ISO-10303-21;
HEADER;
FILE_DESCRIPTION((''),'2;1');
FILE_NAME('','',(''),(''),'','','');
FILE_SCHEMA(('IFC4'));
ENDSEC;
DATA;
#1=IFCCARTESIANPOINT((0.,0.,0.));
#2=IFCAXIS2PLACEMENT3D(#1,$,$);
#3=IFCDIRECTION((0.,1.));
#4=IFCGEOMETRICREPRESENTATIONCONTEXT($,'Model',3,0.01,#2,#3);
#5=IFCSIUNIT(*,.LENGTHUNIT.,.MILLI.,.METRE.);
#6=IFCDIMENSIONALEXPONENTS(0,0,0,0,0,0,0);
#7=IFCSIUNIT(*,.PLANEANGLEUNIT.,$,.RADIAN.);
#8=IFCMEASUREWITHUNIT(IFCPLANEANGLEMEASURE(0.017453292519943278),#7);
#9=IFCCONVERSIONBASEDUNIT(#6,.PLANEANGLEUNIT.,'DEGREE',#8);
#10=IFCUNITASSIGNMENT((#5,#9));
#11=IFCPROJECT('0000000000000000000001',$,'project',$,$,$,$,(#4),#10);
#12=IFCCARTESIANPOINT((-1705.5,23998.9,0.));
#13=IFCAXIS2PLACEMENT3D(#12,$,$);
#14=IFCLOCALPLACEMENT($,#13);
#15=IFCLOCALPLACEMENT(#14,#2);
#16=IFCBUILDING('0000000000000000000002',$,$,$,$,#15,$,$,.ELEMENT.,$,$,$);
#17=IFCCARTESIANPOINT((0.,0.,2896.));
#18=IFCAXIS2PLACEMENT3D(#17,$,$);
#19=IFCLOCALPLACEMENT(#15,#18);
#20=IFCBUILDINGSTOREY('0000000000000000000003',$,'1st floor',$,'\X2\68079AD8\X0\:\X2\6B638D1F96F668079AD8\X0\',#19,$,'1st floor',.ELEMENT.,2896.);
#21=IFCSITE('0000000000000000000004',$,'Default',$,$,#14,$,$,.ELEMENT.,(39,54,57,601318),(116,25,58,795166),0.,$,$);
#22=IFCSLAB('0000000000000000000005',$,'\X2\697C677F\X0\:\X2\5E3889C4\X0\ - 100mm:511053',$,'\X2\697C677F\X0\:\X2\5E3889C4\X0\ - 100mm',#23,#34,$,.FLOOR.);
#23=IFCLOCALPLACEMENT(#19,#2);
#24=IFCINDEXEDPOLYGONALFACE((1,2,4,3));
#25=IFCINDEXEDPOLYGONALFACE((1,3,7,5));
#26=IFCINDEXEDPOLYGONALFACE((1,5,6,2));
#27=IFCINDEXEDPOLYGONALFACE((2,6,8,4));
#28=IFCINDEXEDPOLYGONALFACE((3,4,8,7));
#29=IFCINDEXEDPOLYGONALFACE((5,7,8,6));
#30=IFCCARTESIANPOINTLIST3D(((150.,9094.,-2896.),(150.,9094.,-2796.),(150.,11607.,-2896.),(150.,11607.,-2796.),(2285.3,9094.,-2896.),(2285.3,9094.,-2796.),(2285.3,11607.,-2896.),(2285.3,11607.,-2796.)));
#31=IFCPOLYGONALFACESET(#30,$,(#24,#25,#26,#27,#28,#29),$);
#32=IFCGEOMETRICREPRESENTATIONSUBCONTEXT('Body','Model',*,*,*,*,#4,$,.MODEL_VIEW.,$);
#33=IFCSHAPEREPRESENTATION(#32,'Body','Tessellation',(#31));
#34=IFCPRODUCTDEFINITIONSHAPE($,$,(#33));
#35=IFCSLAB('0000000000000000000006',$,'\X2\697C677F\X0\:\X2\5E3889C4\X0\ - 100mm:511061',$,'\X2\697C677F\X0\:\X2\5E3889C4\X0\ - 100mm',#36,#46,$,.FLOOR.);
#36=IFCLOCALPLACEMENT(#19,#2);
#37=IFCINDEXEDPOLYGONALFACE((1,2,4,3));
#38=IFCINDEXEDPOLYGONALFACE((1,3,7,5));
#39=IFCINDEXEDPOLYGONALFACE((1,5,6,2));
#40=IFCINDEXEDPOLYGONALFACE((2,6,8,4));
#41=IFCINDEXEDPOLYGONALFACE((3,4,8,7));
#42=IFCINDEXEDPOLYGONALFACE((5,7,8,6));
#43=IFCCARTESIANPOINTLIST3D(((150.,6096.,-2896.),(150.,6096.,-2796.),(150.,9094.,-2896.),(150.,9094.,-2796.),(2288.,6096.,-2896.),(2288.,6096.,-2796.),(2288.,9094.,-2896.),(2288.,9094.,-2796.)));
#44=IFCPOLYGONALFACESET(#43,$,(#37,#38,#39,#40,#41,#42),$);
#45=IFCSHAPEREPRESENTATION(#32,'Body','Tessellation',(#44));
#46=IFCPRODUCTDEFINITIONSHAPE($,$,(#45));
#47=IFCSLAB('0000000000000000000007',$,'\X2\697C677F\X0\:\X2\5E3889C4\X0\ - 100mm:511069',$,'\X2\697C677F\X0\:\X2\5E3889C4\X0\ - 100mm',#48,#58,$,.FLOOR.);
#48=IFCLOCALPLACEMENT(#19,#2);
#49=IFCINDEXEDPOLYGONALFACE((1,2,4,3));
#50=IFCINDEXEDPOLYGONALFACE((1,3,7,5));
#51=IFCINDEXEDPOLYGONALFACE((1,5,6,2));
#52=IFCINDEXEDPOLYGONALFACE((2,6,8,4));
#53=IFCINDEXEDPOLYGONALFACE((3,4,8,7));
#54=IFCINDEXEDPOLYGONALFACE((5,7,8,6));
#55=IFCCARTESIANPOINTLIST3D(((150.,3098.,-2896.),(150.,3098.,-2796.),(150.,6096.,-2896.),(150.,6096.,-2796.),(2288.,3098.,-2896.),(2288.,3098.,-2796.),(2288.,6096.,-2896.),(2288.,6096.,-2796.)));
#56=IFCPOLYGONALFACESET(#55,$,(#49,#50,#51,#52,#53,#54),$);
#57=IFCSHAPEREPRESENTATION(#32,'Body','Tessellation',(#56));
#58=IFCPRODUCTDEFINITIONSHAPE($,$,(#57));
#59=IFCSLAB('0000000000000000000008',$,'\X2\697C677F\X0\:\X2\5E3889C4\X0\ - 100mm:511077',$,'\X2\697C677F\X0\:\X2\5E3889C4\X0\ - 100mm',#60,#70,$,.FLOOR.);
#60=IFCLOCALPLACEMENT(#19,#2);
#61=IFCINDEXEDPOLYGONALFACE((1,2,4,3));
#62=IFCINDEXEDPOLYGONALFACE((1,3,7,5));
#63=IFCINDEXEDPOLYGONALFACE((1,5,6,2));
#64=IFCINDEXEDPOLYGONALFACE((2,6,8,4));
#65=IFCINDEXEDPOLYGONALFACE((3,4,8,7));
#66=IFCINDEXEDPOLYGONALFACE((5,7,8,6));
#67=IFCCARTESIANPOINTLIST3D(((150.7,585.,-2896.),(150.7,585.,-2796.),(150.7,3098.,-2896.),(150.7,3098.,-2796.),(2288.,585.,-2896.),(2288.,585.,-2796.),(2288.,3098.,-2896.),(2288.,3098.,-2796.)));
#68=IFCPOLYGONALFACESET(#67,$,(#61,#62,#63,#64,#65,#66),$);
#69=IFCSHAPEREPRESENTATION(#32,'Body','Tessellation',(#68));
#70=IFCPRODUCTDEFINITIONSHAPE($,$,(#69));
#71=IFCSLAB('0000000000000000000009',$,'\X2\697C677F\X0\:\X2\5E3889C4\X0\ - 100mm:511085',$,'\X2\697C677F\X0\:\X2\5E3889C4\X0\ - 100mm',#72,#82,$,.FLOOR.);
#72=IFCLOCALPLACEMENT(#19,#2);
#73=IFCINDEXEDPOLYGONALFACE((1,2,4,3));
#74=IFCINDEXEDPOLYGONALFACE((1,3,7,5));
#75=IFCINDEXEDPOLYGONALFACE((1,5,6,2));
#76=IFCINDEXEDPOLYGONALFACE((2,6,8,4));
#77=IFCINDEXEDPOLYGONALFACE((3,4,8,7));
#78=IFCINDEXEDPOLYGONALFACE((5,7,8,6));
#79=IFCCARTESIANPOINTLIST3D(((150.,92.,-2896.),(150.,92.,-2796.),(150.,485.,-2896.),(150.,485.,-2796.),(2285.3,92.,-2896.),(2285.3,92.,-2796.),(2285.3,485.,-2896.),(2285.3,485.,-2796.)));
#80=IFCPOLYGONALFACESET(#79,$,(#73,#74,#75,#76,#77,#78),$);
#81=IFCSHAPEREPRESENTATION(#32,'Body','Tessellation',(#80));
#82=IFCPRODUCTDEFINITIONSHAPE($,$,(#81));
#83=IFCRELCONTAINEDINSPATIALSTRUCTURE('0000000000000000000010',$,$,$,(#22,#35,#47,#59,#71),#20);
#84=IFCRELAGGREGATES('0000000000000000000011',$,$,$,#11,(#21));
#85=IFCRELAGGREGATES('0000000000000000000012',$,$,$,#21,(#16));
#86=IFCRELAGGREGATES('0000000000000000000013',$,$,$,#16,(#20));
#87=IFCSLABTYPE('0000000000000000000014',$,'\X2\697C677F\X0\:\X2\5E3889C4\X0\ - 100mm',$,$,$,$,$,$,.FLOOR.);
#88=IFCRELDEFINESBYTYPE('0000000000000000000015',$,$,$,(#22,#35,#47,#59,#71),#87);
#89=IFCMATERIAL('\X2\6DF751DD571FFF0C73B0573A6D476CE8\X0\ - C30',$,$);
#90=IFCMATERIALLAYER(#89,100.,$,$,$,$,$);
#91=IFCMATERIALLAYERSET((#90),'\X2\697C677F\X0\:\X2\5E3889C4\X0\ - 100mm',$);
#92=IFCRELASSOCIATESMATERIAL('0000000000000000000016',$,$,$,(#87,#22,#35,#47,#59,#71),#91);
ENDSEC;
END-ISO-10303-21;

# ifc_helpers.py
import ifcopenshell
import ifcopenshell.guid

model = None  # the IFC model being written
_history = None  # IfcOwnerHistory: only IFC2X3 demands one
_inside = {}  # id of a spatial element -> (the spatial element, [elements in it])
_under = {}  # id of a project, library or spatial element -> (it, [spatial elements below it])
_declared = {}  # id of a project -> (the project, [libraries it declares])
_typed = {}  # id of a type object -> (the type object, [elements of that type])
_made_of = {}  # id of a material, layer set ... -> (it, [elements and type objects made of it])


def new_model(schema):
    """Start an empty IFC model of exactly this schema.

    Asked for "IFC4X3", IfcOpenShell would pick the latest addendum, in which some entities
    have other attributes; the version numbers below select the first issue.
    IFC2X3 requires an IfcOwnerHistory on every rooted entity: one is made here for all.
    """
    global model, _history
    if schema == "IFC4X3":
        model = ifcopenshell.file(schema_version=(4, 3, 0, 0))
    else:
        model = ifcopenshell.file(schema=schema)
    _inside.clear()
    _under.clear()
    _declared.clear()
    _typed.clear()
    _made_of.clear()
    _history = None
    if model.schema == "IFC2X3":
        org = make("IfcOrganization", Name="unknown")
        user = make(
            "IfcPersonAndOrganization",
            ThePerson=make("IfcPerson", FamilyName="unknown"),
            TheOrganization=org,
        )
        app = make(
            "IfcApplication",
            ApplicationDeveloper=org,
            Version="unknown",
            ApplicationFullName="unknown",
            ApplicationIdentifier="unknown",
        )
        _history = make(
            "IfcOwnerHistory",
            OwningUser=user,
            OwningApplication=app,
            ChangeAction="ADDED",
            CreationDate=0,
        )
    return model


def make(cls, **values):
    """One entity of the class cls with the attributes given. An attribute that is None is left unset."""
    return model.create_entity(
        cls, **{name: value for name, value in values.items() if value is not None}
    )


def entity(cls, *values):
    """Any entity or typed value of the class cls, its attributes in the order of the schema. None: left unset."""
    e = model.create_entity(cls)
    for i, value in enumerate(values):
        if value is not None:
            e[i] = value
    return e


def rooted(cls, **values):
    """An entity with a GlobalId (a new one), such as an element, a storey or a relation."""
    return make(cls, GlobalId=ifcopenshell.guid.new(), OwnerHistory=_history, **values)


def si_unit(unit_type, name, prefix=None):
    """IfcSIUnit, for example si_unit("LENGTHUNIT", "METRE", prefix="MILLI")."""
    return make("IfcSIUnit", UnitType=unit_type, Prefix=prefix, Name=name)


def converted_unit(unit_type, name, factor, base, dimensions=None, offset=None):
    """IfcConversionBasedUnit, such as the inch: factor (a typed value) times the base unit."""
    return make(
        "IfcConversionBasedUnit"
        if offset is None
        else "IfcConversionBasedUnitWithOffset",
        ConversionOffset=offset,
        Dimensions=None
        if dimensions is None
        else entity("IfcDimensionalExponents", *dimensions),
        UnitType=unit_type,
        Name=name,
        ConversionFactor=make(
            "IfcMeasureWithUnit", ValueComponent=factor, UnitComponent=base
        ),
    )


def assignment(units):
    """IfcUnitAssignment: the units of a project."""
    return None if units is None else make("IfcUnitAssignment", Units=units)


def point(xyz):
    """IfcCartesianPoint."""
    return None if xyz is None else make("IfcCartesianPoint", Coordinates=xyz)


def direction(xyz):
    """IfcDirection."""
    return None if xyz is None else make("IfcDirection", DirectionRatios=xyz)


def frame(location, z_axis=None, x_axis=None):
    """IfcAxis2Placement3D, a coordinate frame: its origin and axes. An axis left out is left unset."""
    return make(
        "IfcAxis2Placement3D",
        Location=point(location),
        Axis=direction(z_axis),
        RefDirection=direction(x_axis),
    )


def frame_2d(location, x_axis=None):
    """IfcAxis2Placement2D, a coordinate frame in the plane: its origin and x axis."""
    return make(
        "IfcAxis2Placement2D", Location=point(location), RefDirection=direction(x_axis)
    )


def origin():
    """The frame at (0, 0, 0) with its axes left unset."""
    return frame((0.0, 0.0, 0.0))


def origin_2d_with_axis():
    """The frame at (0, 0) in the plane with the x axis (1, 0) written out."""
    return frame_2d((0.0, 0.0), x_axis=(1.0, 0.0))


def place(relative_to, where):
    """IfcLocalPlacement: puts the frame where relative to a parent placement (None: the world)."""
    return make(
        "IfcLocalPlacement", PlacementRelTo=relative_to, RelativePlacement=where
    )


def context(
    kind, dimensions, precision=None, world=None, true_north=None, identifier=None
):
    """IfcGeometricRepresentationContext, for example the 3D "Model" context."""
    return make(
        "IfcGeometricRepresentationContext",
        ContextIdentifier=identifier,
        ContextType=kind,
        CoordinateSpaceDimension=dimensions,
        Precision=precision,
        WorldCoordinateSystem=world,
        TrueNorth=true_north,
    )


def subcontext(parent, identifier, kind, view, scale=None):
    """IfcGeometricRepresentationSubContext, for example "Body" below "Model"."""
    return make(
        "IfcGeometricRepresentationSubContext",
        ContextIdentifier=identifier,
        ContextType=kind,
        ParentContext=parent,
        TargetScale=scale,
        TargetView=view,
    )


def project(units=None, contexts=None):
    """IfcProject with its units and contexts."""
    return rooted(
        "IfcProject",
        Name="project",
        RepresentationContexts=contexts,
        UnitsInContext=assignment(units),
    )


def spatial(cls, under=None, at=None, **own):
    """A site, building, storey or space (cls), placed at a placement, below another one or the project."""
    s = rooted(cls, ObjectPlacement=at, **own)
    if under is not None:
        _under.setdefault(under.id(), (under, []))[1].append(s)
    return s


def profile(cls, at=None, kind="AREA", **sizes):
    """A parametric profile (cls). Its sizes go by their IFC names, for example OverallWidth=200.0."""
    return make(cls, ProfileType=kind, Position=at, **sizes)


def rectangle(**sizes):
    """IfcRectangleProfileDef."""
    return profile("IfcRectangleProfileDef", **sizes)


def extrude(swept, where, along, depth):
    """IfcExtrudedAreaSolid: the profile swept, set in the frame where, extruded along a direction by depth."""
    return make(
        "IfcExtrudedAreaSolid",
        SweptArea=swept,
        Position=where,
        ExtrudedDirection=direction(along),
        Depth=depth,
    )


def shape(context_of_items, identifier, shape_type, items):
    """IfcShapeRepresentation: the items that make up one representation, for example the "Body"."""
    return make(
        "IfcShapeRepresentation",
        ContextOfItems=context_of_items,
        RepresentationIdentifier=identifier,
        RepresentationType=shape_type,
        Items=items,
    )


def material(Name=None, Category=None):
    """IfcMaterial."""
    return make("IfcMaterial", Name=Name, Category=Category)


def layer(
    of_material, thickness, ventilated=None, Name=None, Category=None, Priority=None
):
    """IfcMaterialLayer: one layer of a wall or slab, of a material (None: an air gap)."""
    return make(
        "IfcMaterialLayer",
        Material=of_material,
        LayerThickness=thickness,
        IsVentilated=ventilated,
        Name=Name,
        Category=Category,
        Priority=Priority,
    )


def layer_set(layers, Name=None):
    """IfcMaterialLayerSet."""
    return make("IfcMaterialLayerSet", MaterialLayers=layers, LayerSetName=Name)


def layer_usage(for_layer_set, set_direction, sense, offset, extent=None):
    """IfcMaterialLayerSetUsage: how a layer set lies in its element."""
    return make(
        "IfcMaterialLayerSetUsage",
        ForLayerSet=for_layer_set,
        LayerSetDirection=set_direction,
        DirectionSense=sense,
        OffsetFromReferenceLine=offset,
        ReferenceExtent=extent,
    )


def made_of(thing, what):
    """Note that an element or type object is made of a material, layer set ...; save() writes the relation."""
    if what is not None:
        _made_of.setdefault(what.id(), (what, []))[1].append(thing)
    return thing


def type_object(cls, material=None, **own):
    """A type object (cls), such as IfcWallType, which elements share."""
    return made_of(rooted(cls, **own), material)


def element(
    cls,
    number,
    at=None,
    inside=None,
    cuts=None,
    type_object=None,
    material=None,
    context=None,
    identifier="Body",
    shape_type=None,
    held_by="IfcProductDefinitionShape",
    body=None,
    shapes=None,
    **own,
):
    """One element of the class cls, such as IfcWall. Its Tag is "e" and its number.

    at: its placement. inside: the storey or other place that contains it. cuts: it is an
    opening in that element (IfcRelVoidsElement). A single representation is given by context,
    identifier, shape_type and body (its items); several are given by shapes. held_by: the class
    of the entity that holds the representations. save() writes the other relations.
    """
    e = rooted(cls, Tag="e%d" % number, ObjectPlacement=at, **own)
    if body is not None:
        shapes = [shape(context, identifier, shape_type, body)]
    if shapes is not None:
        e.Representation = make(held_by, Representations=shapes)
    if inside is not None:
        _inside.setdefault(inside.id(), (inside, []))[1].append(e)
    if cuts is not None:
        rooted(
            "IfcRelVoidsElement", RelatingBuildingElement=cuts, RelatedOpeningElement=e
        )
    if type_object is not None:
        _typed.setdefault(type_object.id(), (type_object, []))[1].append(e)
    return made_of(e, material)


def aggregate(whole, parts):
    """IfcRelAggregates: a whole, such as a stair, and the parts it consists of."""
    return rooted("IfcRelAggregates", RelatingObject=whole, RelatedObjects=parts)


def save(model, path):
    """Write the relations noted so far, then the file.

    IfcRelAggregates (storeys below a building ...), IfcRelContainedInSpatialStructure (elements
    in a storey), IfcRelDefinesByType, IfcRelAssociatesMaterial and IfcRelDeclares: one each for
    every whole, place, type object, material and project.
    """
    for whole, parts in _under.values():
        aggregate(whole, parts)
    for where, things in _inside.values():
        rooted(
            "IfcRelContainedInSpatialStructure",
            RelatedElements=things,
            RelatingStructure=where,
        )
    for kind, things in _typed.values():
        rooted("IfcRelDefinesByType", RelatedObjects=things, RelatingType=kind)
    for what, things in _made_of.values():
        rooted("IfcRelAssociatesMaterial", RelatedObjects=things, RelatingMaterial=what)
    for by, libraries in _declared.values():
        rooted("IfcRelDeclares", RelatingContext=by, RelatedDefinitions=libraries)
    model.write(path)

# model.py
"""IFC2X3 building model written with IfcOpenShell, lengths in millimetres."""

from ifc_helpers import new_model, entity, si_unit, converted_unit, direction, frame, frame_2d, origin, origin_2d_with_axis, place, context, subcontext, project, spatial, rectangle, extrude, material, layer, layer_set, layer_usage, type_object, element, save


model = new_model("IFC2X3")

# Units and contexts
model_context = context("Model", 3, precision=0.01, world=origin(), true_north=direction((0.0, 1.0)))
body_context = subcontext(model_context, "Body", "Model", "MODEL_VIEW")
ifc_project = project(units=[si_unit("LENGTHUNIT", "METRE", prefix="MILLI"), converted_unit("PLANEANGLEUNIT", "DEGREE", entity("IfcPlaneAngleMeasure", 0.017453292519943278), si_unit("PLANEANGLEUNIT", "RADIAN"), dimensions=[0, 0, 0, 0, 0, 0, 0])], contexts=[model_context])

# Site, building, storey
site_placement = place(None, frame((-1705.5, 23998.9, 0.0)))
site = spatial("IfcSite", under=ifc_project, at=site_placement, Name="Default", CompositionType="ELEMENT", RefLatitude=(39, 54, 57, 601318), RefLongitude=(116, 25, 58, 795166), RefElevation=0.0)
building_placement = place(site_placement, origin())
building = spatial("IfcBuilding", under=site, at=building_placement, CompositionType="ELEMENT")
storey_placement = place(building_placement, frame((0.0, 0.0, 2896.0)))
storey = spatial("IfcBuildingStorey", under=building, at=storey_placement, Name="1st floor", ObjectType="标高:正负零标高", LongName="1st floor", CompositionType="ELEMENT", Elevation=2896.0)

# Slabs
ifc_material_1 = material(Name="混凝土，现场浇注 - C30")
ifc_layer_1 = layer(ifc_material_1, 100.0)
ifc_layer_set_1 = layer_set([ifc_layer_1], Name="楼板:常规 - 100mm")
slab_type = type_object("IfcSlabType", Name="楼板:常规 - 100mm", PredefinedType="FLOOR", material=ifc_layer_set_1)
ifc_layer_usage_1 = layer_usage(ifc_layer_set_1, "AXIS3", "POSITIVE", 0.0)
slab_1_placement = place(storey_placement, origin())
element("IfcSlab", 1, at=slab_1_placement, inside=storey, type_object=slab_type, material=ifc_layer_usage_1, Name="楼板:常规 - 100mm:511053", ObjectType="楼板:常规 - 100mm", PredefinedType="FLOOR", context=body_context, shape_type="SweptSolid", body=[
    extrude(rectangle(XDim=2513.0, YDim=2135.3, at=frame_2d((0.0, 0.0), x_axis=(1.0, 0.0))), frame((1217.6, 10350.5, -2796.0), z_axis=(0.0, 0.0, -1.0), x_axis=(0.0, 1.0, 0.0)), (0.0, 0.0, 1.0), 100.0),
])
ifc_layer_usage_2 = layer_usage(ifc_layer_set_1, "AXIS3", "POSITIVE", 0.0)
slab_2_placement = place(storey_placement, origin())
element("IfcSlab", 2, at=slab_2_placement, inside=storey, type_object=slab_type, material=ifc_layer_usage_2, Name="楼板:常规 - 100mm:511061", ObjectType="楼板:常规 - 100mm", PredefinedType="FLOOR", context=body_context, shape_type="SweptSolid", body=[
    extrude(rectangle(XDim=2998.0, YDim=2138.0, at=origin_2d_with_axis()), frame((1219.0, 7595.0, -2796.0), z_axis=(0.0, 0.0, -1.0), x_axis=(0.0, 1.0, 0.0)), (0.0, 0.0, 1.0), 100.0),
])
ifc_layer_usage_3 = layer_usage(ifc_layer_set_1, "AXIS3", "POSITIVE", 0.0)
slab_3_placement = place(storey_placement, origin())
element("IfcSlab", 3, at=slab_3_placement, inside=storey, type_object=slab_type, material=ifc_layer_usage_3, Name="楼板:常规 - 100mm:511069", ObjectType="楼板:常规 - 100mm", PredefinedType="FLOOR", context=body_context, shape_type="SweptSolid", body=[
    extrude(rectangle(XDim=2998.0, YDim=2138.0, at=origin_2d_with_axis()), frame((1219.0, 4597.0, -2796.0), z_axis=(0.0, 0.0, -1.0), x_axis=(0.0, 1.0, 0.0)), (0.0, 0.0, 1.0), 100.0),
])
ifc_layer_usage_4 = layer_usage(ifc_layer_set_1, "AXIS3", "POSITIVE", 0.0)
slab_4_placement = place(storey_placement, origin())
element("IfcSlab", 4, at=slab_4_placement, inside=storey, type_object=slab_type, material=ifc_layer_usage_4, Name="楼板:常规 - 100mm:511077", ObjectType="楼板:常规 - 100mm", PredefinedType="FLOOR", context=body_context, shape_type="SweptSolid", body=[
    extrude(rectangle(XDim=2513.0, YDim=2137.3, at=frame_2d((0.0, 0.0), x_axis=(1.0, 0.0))), frame((1219.3, 1841.5, -2796.0), z_axis=(0.0, 0.0, -1.0), x_axis=(0.0, 1.0, 0.0)), (0.0, 0.0, 1.0), 100.0),
])
ifc_layer_usage_5 = layer_usage(ifc_layer_set_1, "AXIS3", "POSITIVE", 0.0)
slab_5_placement = place(storey_placement, origin())
element("IfcSlab", 5, at=slab_5_placement, inside=storey, type_object=slab_type, material=ifc_layer_usage_5, Name="楼板:常规 - 100mm:511085", ObjectType="楼板:常规 - 100mm", PredefinedType="FLOOR", context=body_context, shape_type="SweptSolid", body=[
    extrude(rectangle(XDim=393.0, YDim=2135.3, at=frame_2d((0.0, 0.0), x_axis=(1.0, 0.0))), frame((1217.7, 288.5, -2796.0), z_axis=(0.0, 0.0, -1.0), x_axis=(0.0, 1.0, 0.0)), (0.0, 0.0, 1.0), 100.0),
])

save(model, "model.ifc")
